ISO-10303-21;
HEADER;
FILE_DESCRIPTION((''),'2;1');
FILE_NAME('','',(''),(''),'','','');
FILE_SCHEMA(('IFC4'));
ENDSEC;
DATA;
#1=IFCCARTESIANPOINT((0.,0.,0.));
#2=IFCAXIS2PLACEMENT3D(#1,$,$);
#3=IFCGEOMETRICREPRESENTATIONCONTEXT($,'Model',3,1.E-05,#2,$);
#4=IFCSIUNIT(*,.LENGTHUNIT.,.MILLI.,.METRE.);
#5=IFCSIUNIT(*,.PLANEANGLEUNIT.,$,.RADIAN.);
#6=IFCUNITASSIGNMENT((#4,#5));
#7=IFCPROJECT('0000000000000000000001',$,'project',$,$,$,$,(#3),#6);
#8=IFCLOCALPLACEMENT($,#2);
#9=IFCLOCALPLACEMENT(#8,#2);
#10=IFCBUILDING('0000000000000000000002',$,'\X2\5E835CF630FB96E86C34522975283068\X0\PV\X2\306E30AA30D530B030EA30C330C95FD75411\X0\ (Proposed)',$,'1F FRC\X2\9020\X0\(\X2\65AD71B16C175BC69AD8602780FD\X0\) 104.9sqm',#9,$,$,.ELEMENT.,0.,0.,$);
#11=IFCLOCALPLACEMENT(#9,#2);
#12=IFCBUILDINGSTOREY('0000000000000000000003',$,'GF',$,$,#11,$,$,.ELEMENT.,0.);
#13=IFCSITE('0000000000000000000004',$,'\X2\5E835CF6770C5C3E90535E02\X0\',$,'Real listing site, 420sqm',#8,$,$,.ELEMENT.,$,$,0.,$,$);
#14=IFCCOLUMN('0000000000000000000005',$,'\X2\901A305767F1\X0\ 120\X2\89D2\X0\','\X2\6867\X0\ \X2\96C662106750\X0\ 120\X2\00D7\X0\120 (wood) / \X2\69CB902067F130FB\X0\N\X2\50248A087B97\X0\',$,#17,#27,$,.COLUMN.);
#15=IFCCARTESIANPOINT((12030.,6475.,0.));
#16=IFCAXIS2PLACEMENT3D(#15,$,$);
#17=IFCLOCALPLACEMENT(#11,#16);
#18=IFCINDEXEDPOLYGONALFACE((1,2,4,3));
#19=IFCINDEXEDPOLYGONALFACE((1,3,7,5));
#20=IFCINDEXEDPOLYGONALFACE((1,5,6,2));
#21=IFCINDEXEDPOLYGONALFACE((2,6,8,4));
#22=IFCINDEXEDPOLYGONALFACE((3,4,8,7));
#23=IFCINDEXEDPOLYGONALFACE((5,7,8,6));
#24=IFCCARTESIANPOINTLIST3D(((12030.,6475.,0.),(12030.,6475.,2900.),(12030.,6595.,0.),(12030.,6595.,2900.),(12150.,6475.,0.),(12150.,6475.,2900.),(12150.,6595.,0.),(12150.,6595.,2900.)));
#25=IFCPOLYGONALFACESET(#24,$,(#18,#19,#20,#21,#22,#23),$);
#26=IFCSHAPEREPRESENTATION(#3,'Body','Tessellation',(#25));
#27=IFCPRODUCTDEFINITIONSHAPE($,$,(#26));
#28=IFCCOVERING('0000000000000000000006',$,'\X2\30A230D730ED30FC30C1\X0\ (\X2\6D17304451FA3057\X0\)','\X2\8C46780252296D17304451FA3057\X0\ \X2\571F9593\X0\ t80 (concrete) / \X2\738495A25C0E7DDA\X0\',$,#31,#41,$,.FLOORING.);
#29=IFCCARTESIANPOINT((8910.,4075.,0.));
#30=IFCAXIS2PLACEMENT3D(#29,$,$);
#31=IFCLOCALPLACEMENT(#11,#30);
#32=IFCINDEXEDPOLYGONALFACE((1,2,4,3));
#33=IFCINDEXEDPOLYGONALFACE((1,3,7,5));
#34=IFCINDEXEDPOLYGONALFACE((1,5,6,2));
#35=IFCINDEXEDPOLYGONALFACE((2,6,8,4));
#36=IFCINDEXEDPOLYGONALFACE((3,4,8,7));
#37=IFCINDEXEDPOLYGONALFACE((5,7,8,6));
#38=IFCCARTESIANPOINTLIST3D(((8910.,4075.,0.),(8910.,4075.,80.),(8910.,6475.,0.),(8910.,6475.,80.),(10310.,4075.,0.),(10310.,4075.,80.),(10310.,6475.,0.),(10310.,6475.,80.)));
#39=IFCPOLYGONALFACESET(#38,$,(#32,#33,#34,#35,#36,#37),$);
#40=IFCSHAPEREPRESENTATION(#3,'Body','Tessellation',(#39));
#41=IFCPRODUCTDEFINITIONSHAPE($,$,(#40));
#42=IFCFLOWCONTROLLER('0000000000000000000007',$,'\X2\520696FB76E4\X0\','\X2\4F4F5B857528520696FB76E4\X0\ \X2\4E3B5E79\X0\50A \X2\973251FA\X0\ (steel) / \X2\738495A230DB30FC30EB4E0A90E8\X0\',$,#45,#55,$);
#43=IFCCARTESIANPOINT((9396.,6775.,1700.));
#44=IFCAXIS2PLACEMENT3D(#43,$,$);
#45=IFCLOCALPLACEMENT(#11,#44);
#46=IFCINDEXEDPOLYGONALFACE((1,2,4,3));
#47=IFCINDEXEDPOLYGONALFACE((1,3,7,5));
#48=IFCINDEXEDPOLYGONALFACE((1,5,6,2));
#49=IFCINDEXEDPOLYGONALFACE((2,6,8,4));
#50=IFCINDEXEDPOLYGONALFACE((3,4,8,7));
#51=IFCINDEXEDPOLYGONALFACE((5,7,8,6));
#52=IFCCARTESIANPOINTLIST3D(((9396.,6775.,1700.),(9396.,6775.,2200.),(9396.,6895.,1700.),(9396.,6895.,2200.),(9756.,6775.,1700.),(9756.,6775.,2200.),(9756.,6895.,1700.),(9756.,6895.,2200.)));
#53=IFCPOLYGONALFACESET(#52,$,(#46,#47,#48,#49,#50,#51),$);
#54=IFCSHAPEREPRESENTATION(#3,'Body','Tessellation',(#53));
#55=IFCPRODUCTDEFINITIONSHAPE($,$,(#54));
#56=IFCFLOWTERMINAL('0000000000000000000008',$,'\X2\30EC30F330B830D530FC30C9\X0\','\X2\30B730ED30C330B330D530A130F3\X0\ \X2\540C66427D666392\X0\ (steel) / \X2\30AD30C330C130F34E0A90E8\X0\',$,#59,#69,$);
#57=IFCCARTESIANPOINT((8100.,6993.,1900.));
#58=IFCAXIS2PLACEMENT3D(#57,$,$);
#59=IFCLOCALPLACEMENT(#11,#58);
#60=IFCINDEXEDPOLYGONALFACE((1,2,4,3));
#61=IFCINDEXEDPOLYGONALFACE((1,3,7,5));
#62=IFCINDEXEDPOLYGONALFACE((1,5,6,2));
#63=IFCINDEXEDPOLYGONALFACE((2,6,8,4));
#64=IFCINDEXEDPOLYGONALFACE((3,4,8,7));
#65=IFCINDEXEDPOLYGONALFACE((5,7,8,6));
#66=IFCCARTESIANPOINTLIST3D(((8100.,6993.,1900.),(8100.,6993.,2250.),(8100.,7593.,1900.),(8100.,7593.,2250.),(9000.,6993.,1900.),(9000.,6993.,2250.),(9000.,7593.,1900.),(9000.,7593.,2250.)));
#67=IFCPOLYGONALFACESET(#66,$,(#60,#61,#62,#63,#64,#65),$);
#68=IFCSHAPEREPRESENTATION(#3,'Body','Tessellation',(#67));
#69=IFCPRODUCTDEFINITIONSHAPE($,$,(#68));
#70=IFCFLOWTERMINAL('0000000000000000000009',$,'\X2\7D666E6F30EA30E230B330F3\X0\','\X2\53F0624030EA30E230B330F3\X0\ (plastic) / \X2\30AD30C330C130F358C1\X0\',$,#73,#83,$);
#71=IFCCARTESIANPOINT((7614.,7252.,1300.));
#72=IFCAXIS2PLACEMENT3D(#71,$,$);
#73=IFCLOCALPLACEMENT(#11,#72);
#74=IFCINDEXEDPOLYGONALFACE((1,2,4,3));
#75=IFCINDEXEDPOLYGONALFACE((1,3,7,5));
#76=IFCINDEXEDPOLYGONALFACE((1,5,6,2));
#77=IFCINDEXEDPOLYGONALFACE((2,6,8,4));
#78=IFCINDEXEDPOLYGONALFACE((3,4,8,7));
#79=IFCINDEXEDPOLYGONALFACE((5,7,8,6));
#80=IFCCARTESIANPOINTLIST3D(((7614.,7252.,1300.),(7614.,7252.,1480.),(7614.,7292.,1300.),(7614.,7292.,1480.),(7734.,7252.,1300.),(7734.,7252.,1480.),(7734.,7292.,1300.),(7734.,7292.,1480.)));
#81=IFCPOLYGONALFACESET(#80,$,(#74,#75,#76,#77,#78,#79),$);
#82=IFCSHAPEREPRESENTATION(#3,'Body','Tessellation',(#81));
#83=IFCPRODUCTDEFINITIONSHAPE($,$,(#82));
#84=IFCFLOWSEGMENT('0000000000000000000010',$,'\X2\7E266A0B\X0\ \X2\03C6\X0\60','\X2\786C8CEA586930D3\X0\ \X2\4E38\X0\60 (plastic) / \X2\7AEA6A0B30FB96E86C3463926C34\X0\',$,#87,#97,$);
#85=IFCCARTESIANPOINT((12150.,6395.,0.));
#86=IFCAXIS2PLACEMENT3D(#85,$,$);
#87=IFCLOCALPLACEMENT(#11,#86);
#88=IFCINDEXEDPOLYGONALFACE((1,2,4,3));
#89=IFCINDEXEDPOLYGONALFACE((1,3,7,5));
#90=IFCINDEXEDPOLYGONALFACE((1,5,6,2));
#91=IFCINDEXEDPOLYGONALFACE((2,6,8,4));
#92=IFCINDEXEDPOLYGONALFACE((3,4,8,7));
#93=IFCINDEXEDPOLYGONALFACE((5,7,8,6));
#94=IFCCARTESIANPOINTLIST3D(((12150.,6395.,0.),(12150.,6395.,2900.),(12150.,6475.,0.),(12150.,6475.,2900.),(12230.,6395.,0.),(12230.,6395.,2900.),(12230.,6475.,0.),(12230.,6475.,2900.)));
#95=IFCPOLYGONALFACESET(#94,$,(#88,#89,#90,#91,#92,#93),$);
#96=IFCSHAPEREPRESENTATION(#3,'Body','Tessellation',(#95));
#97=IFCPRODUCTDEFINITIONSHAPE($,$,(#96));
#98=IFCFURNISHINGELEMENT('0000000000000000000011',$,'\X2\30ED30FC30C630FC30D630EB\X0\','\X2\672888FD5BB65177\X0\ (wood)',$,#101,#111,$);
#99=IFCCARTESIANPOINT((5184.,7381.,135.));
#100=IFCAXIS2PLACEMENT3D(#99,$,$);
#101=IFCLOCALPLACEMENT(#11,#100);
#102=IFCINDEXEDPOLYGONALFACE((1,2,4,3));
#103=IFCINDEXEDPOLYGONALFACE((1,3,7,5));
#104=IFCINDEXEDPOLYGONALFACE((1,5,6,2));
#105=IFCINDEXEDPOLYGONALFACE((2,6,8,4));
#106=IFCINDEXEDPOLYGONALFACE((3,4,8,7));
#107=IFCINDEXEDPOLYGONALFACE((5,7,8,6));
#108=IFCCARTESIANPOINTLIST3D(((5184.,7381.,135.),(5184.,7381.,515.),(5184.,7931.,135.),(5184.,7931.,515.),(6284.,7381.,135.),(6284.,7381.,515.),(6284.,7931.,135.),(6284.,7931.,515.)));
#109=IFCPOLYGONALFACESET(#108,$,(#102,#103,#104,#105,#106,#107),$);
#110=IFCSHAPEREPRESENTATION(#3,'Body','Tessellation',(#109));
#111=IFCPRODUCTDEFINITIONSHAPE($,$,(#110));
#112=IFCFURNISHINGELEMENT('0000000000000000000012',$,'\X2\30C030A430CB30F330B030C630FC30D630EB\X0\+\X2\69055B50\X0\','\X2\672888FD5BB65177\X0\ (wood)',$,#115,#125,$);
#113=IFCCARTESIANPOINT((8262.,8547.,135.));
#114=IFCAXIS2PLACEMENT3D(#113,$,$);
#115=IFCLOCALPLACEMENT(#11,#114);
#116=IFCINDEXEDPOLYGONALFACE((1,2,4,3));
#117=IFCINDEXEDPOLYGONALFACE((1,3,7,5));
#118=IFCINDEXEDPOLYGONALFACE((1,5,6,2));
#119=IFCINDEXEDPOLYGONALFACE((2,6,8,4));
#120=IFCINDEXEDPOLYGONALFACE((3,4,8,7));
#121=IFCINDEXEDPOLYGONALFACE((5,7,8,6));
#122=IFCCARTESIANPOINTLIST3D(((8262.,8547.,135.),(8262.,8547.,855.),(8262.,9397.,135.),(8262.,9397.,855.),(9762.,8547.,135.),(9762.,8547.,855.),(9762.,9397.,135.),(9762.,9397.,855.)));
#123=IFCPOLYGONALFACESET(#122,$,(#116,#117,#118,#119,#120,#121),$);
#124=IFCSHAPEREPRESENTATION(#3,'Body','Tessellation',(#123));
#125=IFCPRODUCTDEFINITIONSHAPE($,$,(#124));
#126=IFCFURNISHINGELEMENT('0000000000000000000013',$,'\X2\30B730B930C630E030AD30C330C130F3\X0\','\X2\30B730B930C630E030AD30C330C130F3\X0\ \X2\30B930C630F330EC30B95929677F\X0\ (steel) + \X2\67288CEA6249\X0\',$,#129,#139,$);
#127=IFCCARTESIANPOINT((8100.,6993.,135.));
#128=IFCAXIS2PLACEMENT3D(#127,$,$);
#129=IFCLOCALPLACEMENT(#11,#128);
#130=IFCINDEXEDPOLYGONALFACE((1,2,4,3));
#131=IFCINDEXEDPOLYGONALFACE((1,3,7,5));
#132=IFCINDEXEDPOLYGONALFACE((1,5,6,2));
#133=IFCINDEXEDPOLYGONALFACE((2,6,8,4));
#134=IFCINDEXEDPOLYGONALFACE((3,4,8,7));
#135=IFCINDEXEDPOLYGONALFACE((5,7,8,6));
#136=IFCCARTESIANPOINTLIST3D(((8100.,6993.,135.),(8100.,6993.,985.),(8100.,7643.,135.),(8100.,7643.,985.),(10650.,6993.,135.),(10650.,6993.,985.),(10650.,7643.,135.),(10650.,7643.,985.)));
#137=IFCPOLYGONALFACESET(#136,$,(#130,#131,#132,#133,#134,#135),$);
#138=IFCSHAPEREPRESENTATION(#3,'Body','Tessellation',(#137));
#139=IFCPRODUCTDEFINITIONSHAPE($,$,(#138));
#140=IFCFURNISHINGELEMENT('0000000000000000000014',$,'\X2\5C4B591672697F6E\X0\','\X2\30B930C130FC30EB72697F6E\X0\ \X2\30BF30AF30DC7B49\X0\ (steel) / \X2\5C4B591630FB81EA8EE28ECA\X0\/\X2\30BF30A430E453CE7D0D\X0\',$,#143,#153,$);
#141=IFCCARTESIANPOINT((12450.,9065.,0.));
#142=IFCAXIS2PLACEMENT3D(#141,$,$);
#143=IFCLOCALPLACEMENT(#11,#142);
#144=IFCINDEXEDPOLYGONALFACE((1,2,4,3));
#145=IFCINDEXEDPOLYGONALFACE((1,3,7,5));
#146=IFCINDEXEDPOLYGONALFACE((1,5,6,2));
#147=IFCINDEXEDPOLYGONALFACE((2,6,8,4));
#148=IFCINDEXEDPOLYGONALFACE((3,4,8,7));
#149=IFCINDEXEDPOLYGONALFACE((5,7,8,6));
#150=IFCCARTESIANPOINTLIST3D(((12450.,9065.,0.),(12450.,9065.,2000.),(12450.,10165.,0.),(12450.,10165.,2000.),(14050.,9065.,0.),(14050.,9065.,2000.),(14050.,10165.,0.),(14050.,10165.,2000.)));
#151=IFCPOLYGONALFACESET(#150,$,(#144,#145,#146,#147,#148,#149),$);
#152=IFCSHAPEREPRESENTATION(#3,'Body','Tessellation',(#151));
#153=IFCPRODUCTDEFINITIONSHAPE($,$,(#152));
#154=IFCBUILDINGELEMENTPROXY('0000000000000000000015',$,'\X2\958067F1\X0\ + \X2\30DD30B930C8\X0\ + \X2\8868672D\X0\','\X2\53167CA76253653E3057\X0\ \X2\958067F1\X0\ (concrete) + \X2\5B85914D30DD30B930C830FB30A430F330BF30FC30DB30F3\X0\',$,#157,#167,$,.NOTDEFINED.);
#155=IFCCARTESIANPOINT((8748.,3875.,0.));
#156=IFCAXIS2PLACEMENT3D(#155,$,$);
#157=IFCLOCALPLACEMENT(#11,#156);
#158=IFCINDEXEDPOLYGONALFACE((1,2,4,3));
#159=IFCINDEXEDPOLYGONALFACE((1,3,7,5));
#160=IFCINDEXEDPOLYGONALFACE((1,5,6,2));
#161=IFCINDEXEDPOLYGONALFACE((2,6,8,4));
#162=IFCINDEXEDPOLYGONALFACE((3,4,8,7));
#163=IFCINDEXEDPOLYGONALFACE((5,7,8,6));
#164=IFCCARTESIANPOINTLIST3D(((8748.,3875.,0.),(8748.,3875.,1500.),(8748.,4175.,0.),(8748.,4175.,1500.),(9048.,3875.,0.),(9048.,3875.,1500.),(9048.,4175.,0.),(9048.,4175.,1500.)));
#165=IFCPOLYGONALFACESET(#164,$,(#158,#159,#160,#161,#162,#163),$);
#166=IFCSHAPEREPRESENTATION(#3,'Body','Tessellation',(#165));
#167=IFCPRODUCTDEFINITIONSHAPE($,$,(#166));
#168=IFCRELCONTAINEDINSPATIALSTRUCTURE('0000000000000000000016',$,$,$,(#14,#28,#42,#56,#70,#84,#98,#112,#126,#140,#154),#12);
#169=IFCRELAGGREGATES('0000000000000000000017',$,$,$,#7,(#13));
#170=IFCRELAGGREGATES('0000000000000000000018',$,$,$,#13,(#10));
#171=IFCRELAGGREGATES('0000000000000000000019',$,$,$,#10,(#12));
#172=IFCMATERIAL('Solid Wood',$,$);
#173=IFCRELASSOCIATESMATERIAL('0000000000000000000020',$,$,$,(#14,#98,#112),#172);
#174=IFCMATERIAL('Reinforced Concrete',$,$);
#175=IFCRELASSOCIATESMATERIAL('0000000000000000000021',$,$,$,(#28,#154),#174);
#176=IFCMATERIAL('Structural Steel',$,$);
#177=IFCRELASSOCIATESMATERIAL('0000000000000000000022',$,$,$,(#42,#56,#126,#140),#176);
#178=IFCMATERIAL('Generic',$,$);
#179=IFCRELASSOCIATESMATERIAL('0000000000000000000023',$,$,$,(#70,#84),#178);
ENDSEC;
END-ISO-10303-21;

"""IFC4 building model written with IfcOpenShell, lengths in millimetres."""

from ifc_helpers import new_model, si_unit, frame, frame_2d, origin, place, context, project, spatial, rectangle, extrude, material, element, save


model = new_model("IFC4")

# Units and contexts
model_context = context("Model", 3, precision=1e-05, world=origin())
ifc_project = project(units=[si_unit("LENGTHUNIT", "METRE", prefix="MILLI"), si_unit("PLANEANGLEUNIT", "RADIAN")], contexts=[model_context])

# Site, building, storey
site_placement = place(None, origin())
site = spatial("IfcSite", under=ifc_project, at=site_placement, Name="広島県尾道市", ObjectType="Real listing site, 420sqm", CompositionType="ELEMENT", RefElevation=0.0)
building_placement = place(site_placement, origin())
building = spatial("IfcBuilding", under=site, at=building_placement, Name="広島・雨水利用とPVのオフグリッド志向 (Proposed)", ObjectType="1F FRC造(断熱気密高性能) 104.9sqm", CompositionType="ELEMENT", ElevationOfRefHeight=0.0, ElevationOfTerrain=0.0)
storey_placement = place(building_placement, origin())
storey = spatial("IfcBuildingStorey", under=building, at=storey_placement, Name="GF", CompositionType="ELEMENT", Elevation=0.0)

# Column
ifc_material_1 = material(Name="Solid Wood")
column_1_placement = place(storey_placement, frame((12030.0, 6475.0, 0.0)))
element("IfcColumn", 1, at=column_1_placement, inside=storey, material=ifc_material_1, Name="通し柱 120角", Description="桧 集成材 120×120 (wood) / 構造柱・N値計算", PredefinedType="COLUMN", context=model_context, shape_type="SweptSolid", body=[
    extrude(rectangle(XDim=120.0, YDim=120.0, at=frame_2d((60.0, 60.0))), frame((12030.0, 6475.0, 0.0)), (0.0, 0.0, 1.0), 2900.0),
])

# Covering
ifc_material_2 = material(Name="Reinforced Concrete")
covering_placement = place(storey_placement, frame((8910.0, 4075.0, 0.0)))
element("IfcCovering", 2, at=covering_placement, inside=storey, material=ifc_material_2, Name="アプローチ (洗い出し)", Description="豆砂利洗い出し 土間 t80 (concrete) / 玄関導線", PredefinedType="FLOORING", context=model_context, shape_type="SweptSolid", body=[
    extrude(rectangle(XDim=1400.0, YDim=2400.0, at=frame_2d((700.0, 1200.0))), frame((8910.0, 4075.0, 0.0)), (0.0, 0.0, 1.0), 80.0),
])

# Flow controller
ifc_material_3 = material(Name="Structural Steel")
flow_controller_placement = place(storey_placement, frame((9396.0, 6775.0, 1700.0)))
element("IfcFlowController", 3, at=flow_controller_placement, inside=storey, material=ifc_material_3, Name="分電盤", Description="住宅用分電盤 主幹50A 露出 (steel) / 玄関ホール上部", context=model_context, shape_type="SweptSolid", body=[
    extrude(rectangle(XDim=360.0, YDim=120.0, at=frame_2d((180.0, 60.0))), frame((9396.0, 6775.0, 1700.0)), (0.0, 0.0, 1.0), 500.0),
])

# Flow terminals
flow_terminal_1_placement = place(storey_placement, frame((8100.0, 6993.0, 1900.0)))
element("IfcFlowTerminal", 4, at=flow_terminal_1_placement, inside=storey, material=ifc_material_3, Name="レンジフード", Description="シロッコファン 同時給排 (steel) / キッチン上部", context=model_context, shape_type="SweptSolid", body=[
    extrude(rectangle(XDim=900.0, YDim=600.0, at=frame_2d((450.0, 300.0))), frame((8100.0, 6993.0, 1900.0)), (0.0, 0.0, 1.0), 350.0),
])
ifc_material_4 = material(Name="Generic")
flow_terminal_2_placement = place(storey_placement, frame((7614.0, 7252.0, 1300.0)))
element("IfcFlowTerminal", 5, at=flow_terminal_2_placement, inside=storey, material=ifc_material_4, Name="給湯リモコン", Description="台所リモコン (plastic) / キッチン壁", context=model_context, shape_type="SweptSolid", body=[
    extrude(rectangle(XDim=120.0, YDim=40.0, at=frame_2d((60.0, 20.0))), frame((7614.0, 7252.0, 1300.0)), (0.0, 0.0, 1.0), 180.0),
])

# Flow segment
flow_segment_placement = place(storey_placement, frame((12150.0, 6395.0, 0.0)))
element("IfcFlowSegment", 6, at=flow_segment_placement, inside=storey, material=ifc_material_4, Name="縦樋 φ60", Description="硬質塩ビ 丸60 (plastic) / 竪樋・雨水排水", context=model_context, shape_type="SweptSolid", body=[
    extrude(rectangle(XDim=80.0, YDim=80.0, at=frame_2d((40.0, 40.0))), frame((12150.0, 6395.0, 0.0)), (0.0, 0.0, 1.0), 2900.0),
])

# Furnishing elements
furnishing_1_placement = place(storey_placement, frame((5184.0, 7381.0, 135.0)))
element("IfcFurnishingElement", 7, at=furnishing_1_placement, inside=storey, material=ifc_material_1, Name="ローテーブル", Description="木製家具 (wood)", context=model_context, shape_type="SweptSolid", body=[
    extrude(rectangle(XDim=1100.0, YDim=550.0, at=frame_2d((550.0, 275.0))), frame((5184.0, 7381.0, 135.0)), (0.0, 0.0, 1.0), 380.0),
])
furnishing_2_placement = place(storey_placement, frame((8262.0, 8547.0, 135.0)))
element("IfcFurnishingElement", 8, at=furnishing_2_placement, inside=storey, material=ifc_material_1, Name="ダイニングテーブル+椅子", Description="木製家具 (wood)", context=model_context, shape_type="SweptSolid", body=[
    extrude(rectangle(XDim=1500.0, YDim=850.0, at=frame_2d((750.0, 425.0))), frame((8262.0, 8547.0, 135.0)), (0.0, 0.0, 1.0), 720.0),
])
furnishing_3_placement = place(storey_placement, frame((8100.0, 6993.0, 135.0)))
element("IfcFurnishingElement", 9, at=furnishing_3_placement, inside=storey, material=ifc_material_3, Name="システムキッチン", Description="システムキッチン ステンレス天板 (steel) + 木質扉", context=model_context, shape_type="SweptSolid", body=[
    extrude(rectangle(XDim=2550.0, YDim=650.0, at=frame_2d((1275.0, 325.0))), frame((8100.0, 6993.0, 135.0)), (0.0, 0.0, 1.0), 850.0),
])
furnishing_4_placement = place(storey_placement, frame((12450.0, 9065.0, 0.0)))
element("IfcFurnishingElement", 10, at=furnishing_4_placement, inside=storey, material=ifc_material_3, Name="屋外物置", Description="スチール物置 タクボ等 (steel) / 屋外・自転車/タイヤ収納", context=model_context, shape_type="SweptSolid", body=[
    extrude(rectangle(XDim=1600.0, YDim=1100.0, at=frame_2d((800.0, 550.0))), frame((12450.0, 9065.0, 0.0)), (0.0, 0.0, 1.0), 2000.0),
])

# Building element proxy
proxy_placement = place(storey_placement, frame((8748.0, 3875.0, 0.0)))
element("IfcBuildingElementProxy", 11, at=proxy_placement, inside=storey, material=ifc_material_2, Name="門柱 + ポスト + 表札", Description="化粧打放し 門柱 (concrete) + 宅配ポスト・インターホン", PredefinedType="NOTDEFINED", context=model_context, shape_type="SweptSolid", body=[
    extrude(rectangle(XDim=300.0, YDim=300.0, at=frame_2d((150.0, 150.0))), frame((8748.0, 3875.0, 0.0)), (0.0, 0.0, 1.0), 1500.0),
])

save(model, "model.ifc")
